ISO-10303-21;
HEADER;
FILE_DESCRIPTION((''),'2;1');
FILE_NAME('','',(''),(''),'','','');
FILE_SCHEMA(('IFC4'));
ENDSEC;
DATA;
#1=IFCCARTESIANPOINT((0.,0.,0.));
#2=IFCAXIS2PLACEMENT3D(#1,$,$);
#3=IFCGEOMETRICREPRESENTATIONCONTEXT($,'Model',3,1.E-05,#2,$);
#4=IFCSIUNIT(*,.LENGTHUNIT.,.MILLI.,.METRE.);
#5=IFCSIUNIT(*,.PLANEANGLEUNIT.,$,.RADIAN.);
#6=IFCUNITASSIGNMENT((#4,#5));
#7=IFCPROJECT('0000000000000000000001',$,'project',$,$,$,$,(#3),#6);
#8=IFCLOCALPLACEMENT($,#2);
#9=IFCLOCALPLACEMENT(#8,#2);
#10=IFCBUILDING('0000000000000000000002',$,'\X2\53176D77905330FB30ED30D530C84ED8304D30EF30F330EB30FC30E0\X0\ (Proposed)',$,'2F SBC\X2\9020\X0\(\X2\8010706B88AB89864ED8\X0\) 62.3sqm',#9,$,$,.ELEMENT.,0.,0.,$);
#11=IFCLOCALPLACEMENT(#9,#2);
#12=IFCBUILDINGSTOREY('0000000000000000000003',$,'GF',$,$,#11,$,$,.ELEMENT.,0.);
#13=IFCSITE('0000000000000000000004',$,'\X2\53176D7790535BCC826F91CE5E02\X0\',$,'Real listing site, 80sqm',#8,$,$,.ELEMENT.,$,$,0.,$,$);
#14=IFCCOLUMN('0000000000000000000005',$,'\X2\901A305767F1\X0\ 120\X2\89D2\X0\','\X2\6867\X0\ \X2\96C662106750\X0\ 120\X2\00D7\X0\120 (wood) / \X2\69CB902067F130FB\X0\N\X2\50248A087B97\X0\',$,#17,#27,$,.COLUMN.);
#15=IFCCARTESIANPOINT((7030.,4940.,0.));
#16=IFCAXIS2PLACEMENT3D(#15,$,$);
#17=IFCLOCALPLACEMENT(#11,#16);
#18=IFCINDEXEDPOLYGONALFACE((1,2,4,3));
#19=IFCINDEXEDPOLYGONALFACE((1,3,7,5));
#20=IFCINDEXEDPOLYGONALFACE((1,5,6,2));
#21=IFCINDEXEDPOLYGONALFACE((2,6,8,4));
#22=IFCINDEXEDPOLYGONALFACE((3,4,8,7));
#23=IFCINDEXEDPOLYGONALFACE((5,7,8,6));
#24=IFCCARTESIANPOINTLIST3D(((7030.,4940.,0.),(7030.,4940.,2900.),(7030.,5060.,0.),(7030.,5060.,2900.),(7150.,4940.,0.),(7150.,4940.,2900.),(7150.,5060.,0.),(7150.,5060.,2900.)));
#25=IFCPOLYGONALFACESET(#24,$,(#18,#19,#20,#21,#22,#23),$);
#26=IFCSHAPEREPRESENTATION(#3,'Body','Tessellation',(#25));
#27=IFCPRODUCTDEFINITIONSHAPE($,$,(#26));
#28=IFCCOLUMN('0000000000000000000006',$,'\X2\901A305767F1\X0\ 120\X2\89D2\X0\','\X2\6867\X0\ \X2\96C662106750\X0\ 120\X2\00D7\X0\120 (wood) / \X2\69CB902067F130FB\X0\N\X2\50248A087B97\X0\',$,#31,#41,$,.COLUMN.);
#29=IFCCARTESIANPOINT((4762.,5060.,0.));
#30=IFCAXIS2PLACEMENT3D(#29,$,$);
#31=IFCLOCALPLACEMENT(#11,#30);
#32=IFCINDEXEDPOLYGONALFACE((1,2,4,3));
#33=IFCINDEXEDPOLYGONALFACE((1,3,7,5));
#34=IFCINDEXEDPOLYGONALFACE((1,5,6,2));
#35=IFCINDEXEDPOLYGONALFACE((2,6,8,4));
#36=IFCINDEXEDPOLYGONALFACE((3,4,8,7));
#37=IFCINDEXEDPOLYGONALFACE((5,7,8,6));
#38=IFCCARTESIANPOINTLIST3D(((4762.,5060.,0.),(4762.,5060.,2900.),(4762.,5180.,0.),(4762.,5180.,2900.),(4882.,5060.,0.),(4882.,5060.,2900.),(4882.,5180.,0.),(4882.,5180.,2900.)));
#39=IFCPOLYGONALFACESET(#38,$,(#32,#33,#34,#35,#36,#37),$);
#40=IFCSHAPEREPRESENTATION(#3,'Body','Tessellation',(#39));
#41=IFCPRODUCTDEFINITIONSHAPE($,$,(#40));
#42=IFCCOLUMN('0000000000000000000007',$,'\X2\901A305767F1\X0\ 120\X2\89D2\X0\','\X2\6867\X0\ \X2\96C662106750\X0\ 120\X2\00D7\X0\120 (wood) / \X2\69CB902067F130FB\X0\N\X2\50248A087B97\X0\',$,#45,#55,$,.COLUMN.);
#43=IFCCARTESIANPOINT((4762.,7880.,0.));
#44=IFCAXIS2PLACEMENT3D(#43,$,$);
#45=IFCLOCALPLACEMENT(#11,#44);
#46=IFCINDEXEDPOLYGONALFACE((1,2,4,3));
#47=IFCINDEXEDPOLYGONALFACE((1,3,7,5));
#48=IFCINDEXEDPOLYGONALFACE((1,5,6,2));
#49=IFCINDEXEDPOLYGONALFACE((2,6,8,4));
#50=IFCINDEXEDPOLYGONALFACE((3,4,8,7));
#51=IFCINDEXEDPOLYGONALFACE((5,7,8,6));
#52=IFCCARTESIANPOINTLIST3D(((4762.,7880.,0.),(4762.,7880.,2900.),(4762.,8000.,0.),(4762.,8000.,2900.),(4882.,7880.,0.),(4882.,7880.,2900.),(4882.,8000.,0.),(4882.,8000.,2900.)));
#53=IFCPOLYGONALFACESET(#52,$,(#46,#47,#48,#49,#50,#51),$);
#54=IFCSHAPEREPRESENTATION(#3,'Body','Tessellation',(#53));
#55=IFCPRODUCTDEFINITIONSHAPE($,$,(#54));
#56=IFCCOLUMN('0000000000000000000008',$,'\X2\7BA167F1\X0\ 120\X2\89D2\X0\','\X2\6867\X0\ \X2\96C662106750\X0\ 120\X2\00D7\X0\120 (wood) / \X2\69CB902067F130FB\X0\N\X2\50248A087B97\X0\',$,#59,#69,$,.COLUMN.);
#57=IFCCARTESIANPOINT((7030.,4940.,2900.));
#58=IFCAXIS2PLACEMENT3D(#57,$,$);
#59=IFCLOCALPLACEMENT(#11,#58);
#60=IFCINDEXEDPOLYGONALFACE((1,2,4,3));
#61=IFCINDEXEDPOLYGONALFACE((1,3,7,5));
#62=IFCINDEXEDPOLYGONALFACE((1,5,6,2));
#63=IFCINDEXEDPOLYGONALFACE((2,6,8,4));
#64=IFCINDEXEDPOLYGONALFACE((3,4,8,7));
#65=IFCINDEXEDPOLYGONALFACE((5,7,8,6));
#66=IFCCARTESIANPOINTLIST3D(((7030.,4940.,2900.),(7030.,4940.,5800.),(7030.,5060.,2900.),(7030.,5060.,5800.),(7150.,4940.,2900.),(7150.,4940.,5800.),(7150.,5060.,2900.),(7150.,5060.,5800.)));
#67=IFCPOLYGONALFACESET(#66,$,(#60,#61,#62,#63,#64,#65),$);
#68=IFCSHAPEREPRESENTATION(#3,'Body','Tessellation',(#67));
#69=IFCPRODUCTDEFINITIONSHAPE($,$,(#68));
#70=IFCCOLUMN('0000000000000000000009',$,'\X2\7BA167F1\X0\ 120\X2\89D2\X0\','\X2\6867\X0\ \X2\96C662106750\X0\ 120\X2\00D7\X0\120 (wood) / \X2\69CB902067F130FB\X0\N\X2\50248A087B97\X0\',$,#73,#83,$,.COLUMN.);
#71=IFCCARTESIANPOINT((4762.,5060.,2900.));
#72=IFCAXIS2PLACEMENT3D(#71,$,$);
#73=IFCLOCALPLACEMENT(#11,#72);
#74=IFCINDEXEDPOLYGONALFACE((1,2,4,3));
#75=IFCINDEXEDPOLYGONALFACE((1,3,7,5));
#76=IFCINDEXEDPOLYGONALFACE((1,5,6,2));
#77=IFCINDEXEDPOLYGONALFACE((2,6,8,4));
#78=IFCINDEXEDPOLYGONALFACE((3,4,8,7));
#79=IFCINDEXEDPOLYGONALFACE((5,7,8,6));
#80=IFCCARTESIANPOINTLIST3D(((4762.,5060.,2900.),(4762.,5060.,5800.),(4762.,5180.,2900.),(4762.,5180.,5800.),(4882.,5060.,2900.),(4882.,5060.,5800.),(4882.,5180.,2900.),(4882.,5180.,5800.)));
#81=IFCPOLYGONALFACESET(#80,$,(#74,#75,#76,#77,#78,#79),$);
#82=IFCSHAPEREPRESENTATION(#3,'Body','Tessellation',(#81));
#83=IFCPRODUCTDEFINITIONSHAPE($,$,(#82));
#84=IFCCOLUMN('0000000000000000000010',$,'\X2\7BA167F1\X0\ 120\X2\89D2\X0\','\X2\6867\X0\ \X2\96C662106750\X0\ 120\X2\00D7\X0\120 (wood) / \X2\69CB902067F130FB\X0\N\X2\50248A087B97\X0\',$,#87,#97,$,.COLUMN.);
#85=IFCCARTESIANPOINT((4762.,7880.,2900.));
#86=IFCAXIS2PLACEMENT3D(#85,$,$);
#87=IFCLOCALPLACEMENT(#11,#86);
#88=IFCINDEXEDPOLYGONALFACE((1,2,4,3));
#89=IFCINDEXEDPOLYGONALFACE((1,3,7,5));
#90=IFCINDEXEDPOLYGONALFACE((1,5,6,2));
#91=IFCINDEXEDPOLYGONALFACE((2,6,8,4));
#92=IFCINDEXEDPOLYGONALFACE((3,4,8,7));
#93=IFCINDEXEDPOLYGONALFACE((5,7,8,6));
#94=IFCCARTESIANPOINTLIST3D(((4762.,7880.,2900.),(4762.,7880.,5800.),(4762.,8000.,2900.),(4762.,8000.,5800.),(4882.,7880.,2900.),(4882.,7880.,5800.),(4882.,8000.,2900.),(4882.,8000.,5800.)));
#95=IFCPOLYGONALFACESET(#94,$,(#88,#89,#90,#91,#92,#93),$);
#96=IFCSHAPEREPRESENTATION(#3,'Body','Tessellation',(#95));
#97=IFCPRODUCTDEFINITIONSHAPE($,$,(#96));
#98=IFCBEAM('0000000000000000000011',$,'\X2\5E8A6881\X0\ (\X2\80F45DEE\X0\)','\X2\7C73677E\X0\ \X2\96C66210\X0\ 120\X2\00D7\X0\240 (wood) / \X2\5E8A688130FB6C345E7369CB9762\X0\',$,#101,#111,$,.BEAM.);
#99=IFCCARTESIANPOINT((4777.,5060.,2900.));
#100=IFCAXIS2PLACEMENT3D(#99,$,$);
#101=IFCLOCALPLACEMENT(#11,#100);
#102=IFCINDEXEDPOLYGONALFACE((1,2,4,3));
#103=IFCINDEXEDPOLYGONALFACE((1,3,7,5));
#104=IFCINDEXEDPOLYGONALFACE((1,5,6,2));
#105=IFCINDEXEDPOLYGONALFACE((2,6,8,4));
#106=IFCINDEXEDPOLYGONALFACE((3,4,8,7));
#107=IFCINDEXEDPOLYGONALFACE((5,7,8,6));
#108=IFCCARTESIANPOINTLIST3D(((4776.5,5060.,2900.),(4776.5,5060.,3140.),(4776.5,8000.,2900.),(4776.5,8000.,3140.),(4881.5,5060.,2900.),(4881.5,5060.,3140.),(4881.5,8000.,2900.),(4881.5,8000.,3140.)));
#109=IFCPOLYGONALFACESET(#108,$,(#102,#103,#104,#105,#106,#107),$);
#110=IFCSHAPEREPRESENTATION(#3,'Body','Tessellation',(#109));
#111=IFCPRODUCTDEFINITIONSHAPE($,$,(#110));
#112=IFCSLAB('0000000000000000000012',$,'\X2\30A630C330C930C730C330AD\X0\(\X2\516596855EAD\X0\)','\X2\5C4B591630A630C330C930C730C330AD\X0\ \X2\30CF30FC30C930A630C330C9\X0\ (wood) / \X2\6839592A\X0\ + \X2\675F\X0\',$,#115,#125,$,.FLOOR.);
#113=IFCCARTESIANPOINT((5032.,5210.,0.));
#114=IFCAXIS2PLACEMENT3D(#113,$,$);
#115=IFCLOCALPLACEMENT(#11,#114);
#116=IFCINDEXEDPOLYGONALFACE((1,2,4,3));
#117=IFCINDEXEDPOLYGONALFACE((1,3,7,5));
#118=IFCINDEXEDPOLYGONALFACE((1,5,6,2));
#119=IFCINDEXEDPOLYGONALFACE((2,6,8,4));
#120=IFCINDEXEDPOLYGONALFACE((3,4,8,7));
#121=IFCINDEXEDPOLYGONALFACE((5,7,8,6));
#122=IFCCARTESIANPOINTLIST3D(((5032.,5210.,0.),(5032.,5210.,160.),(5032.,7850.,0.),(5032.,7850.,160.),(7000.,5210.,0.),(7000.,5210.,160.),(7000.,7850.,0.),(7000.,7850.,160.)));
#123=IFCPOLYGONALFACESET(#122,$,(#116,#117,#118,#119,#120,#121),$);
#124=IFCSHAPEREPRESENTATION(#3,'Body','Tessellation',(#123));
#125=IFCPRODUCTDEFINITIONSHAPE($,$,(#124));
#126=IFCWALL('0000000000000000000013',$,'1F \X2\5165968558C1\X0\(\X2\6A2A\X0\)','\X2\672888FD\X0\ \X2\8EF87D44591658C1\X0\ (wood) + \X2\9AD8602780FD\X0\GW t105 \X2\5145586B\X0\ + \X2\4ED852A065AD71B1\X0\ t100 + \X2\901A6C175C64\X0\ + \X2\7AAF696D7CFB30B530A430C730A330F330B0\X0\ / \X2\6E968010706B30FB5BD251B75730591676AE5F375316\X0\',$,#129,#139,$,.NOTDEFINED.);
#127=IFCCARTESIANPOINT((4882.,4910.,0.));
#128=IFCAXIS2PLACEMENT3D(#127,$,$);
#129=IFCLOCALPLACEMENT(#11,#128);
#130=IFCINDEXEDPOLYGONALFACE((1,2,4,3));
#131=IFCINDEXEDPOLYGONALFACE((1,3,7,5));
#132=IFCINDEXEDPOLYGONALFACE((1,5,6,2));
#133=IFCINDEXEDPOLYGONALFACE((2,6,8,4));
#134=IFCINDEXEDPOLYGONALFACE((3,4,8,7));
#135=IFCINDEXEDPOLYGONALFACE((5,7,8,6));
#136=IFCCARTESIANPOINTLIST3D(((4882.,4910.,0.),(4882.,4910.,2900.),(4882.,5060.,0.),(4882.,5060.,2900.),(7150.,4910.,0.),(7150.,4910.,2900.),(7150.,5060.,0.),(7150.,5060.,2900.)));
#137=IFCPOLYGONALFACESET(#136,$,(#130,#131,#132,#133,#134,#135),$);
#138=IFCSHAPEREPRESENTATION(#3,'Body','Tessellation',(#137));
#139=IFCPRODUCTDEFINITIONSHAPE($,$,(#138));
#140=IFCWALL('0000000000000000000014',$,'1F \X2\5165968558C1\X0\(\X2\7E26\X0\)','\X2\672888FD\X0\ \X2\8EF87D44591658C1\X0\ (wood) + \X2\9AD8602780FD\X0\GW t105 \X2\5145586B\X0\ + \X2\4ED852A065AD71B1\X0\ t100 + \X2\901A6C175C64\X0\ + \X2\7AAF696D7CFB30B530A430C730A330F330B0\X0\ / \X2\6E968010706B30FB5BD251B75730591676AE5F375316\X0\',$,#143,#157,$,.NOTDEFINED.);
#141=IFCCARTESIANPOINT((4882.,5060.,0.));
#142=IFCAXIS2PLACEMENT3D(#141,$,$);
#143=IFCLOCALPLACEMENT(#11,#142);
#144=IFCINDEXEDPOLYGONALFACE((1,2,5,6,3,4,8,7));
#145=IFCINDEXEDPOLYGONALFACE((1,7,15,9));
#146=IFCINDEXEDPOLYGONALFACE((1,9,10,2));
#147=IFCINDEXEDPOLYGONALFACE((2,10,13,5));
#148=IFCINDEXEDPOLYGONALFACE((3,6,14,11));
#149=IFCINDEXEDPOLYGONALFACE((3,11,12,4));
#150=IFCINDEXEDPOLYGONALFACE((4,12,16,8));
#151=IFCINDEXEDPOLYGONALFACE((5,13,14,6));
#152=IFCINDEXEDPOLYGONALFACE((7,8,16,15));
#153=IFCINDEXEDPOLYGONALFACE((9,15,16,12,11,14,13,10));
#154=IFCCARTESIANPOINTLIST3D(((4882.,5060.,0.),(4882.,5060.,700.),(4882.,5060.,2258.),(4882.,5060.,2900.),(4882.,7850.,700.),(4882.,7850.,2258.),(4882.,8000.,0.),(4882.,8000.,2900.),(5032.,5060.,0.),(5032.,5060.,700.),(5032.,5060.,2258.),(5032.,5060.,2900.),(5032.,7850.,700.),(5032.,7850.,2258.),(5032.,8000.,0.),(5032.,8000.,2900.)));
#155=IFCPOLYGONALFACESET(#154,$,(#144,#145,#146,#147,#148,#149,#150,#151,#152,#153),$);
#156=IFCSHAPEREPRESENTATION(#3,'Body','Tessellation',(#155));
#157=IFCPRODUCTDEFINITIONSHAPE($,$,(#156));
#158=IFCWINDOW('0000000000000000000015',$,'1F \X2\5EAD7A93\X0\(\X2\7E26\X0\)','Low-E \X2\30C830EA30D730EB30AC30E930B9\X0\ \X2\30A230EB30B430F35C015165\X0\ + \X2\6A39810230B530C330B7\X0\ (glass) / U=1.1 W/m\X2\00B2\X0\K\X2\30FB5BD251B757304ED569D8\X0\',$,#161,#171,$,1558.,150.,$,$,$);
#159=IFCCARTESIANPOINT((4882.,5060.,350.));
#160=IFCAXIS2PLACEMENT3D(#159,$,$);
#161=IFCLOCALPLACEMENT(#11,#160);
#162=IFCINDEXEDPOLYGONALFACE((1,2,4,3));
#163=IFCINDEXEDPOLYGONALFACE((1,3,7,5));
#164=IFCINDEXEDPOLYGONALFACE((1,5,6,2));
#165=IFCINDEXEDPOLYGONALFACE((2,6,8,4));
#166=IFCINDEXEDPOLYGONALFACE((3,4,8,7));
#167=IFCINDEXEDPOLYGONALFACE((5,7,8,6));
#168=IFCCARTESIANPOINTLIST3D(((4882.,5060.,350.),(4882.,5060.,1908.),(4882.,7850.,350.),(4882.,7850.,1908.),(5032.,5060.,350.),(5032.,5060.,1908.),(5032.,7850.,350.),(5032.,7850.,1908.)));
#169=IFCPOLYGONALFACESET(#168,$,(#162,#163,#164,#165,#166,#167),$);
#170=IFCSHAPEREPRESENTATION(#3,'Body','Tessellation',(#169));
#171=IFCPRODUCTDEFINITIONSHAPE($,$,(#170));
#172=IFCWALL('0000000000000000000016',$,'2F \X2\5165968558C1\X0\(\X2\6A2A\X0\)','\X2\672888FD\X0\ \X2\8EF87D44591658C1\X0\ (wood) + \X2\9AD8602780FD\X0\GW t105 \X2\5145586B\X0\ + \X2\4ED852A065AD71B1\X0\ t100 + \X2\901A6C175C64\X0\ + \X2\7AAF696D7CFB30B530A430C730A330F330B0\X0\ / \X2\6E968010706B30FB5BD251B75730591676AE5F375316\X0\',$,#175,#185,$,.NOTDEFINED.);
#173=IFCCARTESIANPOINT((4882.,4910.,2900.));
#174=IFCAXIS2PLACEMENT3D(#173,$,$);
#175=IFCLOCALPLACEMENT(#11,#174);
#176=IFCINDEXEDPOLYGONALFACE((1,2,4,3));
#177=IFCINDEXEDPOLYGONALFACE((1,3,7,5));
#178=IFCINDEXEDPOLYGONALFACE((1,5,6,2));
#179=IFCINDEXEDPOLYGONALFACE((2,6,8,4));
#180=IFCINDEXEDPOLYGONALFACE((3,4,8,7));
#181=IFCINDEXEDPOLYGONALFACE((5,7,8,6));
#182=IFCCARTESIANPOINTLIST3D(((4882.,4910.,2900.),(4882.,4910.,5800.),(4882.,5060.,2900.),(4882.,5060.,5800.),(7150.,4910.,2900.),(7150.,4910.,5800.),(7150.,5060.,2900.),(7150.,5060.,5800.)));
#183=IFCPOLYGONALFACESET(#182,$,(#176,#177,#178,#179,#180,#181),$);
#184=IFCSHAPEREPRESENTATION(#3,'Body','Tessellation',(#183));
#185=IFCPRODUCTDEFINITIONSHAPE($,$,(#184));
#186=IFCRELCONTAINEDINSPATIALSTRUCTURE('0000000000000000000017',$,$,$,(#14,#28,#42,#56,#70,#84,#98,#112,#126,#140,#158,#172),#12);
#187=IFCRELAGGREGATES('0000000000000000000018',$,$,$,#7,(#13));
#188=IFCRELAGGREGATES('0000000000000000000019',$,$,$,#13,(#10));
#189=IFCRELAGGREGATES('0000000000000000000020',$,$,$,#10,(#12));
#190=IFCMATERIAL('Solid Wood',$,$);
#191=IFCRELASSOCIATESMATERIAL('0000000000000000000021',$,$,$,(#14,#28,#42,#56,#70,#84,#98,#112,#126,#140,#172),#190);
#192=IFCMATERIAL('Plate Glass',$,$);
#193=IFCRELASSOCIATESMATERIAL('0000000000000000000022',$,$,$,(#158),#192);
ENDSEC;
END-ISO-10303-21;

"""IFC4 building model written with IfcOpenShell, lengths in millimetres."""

from ifc_helpers import new_model, si_unit, frame, frame_2d, origin, place, context, project, spatial, rectangle, extrude, material, element, fill, save


model = new_model("IFC4")

# Units and contexts
model_context = context("Model", 3, precision=1e-05, world=origin())
ifc_project = project(units=[si_unit("LENGTHUNIT", "METRE", prefix="MILLI"), si_unit("PLANEANGLEUNIT", "RADIAN")], contexts=[model_context])

# Site, building, storey
site_placement = place(None, origin())
site = spatial("IfcSite", under=ifc_project, at=site_placement, Name="北海道富良野市", ObjectType="Real listing site, 80sqm", CompositionType="ELEMENT", RefElevation=0.0)
building_placement = place(site_placement, origin())
building = spatial("IfcBuilding", under=site, at=building_placement, Name="北海道・ロフト付きワンルーム (Proposed)", ObjectType="2F SBC造(耐火被覆付) 62.3sqm", CompositionType="ELEMENT", ElevationOfRefHeight=0.0, ElevationOfTerrain=0.0)
storey_placement = place(building_placement, origin())
storey = spatial("IfcBuildingStorey", under=building, at=storey_placement, Name="GF", CompositionType="ELEMENT", Elevation=0.0)

# Columns
ifc_material_1 = material(Name="Solid Wood")
column_1_placement = place(storey_placement, frame((7030.0, 4940.0, 0.0)))
element("IfcColumn", 1, at=column_1_placement, inside=storey, material=ifc_material_1, Name="通し柱 120角", Description="桧 集成材 120×120 (wood) / 構造柱・N値計算", PredefinedType="COLUMN", context=model_context, shape_type="SweptSolid", body=[
    extrude(rectangle(XDim=120.0, YDim=120.0, at=frame_2d((60.0, 60.0))), frame((7030.0, 4940.0, 0.0)), (0.0, 0.0, 1.0), 2900.0),
])
column_2_placement = place(storey_placement, frame((4762.0, 5060.0, 0.0)))
element("IfcColumn", 2, at=column_2_placement, inside=storey, material=ifc_material_1, Name="通し柱 120角", Description="桧 集成材 120×120 (wood) / 構造柱・N値計算", PredefinedType="COLUMN", context=model_context, shape_type="SweptSolid", body=[
    extrude(rectangle(XDim=120.0, YDim=120.0, at=frame_2d((60.0, 60.0))), frame((4762.0, 5060.0, 0.0)), (0.0, 0.0, 1.0), 2900.0),
])
column_3_placement = place(storey_placement, frame((4762.0, 7880.0, 0.0)))
element("IfcColumn", 3, at=column_3_placement, inside=storey, material=ifc_material_1, Name="通し柱 120角", Description="桧 集成材 120×120 (wood) / 構造柱・N値計算", PredefinedType="COLUMN", context=model_context, shape_type="SweptSolid", body=[
    extrude(rectangle(XDim=120.0, YDim=120.0, at=frame_2d((60.0, 60.0))), frame((4762.0, 7880.0, 0.0)), (0.0, 0.0, 1.0), 2900.0),
])
column_4_placement = place(storey_placement, frame((7030.0, 4940.0, 2900.0)))
element("IfcColumn", 4, at=column_4_placement, inside=storey, material=ifc_material_1, Name="管柱 120角", Description="桧 集成材 120×120 (wood) / 構造柱・N値計算", PredefinedType="COLUMN", context=model_context, shape_type="SweptSolid", body=[
    extrude(rectangle(XDim=120.0, YDim=120.0, at=frame_2d((60.0, 60.0))), frame((7030.0, 4940.0, 2900.0)), (0.0, 0.0, 1.0), 2900.0),
])
column_5_placement = place(storey_placement, frame((4762.0, 5060.0, 2900.0)))
element("IfcColumn", 5, at=column_5_placement, inside=storey, material=ifc_material_1, Name="管柱 120角", Description="桧 集成材 120×120 (wood) / 構造柱・N値計算", PredefinedType="COLUMN", context=model_context, shape_type="SweptSolid", body=[
    extrude(rectangle(XDim=120.0, YDim=120.0, at=frame_2d((60.0, 60.0))), frame((4762.0, 5060.0, 2900.0)), (0.0, 0.0, 1.0), 2900.0),
])
column_6_placement = place(storey_placement, frame((4762.0, 7880.0, 2900.0)))
element("IfcColumn", 6, at=column_6_placement, inside=storey, material=ifc_material_1, Name="管柱 120角", Description="桧 集成材 120×120 (wood) / 構造柱・N値計算", PredefinedType="COLUMN", context=model_context, shape_type="SweptSolid", body=[
    extrude(rectangle(XDim=120.0, YDim=120.0, at=frame_2d((60.0, 60.0))), frame((4762.0, 7880.0, 2900.0)), (0.0, 0.0, 1.0), 2900.0),
])

# Beam
beam_1_placement = place(storey_placement, frame((4777.0, 5060.0, 2900.0)))
element("IfcBeam", 7, at=beam_1_placement, inside=storey, material=ifc_material_1, Name="床梁 (胴差)", Description="米松 集成 120×240 (wood) / 床梁・水平構面", PredefinedType="BEAM", context=model_context, shape_type="SweptSolid", body=[
    extrude(rectangle(XDim=105.0, YDim=2940.0, at=frame_2d((52.0, 1470.0))), frame((4777.0, 5060.0, 2900.0)), (0.0, 0.0, 1.0), 240.0),
])

# Slab
slab_placement = place(storey_placement, frame((5032.0, 5210.0, 0.0)))
element("IfcSlab", 8, at=slab_placement, inside=storey, material=ifc_material_1, Name="ウッドデッキ(入隅庭)", Description="屋外ウッドデッキ ハードウッド (wood) / 根太 + 束", PredefinedType="FLOOR", context=model_context, shape_type="SweptSolid", body=[
    extrude(rectangle(XDim=1968.0, YDim=2640.0, at=frame_2d((984.0, 1320.0))), frame((5032.0, 5210.0, 0.0)), (0.0, 0.0, 1.0), 160.0),
])

# Wall
wall_1_placement = place(storey_placement, frame((4882.0, 4910.0, 0.0)))
element("IfcWall", 9, at=wall_1_placement, inside=storey, material=ifc_material_1, Name="1F 入隅壁(横)", Description="木製 軸組外壁 (wood) + 高性能GW t105 充填 + 付加断熱 t100 + 通気層 + 窯業系サイディング / 準耐火・寒冷地外皮強化", PredefinedType="NOTDEFINED", context=model_context, shape_type="SweptSolid", body=[
    extrude(rectangle(XDim=2268.0, YDim=150.0, at=frame_2d((1134.0, 75.0))), frame((4882.0, 4910.0, 0.0)), (0.0, 0.0, 1.0), 2900.0),
])

# Wall, opening, window
wall_2_placement = place(storey_placement, frame((4882.0, 5060.0, 0.0)))
wall_2 = element("IfcWall", 10, at=wall_2_placement, inside=storey, material=ifc_material_1, Name="1F 入隅壁(縦)", Description="木製 軸組外壁 (wood) + 高性能GW t105 充填 + 付加断熱 t100 + 通気層 + 窯業系サイディング / 準耐火・寒冷地外皮強化", PredefinedType="NOTDEFINED", context=model_context, shape_type="SweptSolid", body=[
    extrude(rectangle(XDim=150.0, YDim=2940.0, at=frame_2d((75.0, 1470.0))), frame((4882.0, 5060.0, 0.0)), (0.0, 0.0, 1.0), 2900.0),
])
opening_1_placement = place(storey_placement, frame((4882.0, 5060.0, 350.0)))
opening_1 = element("IfcOpeningElement", 11, at=opening_1_placement, cuts=wall_2, PredefinedType="NOTDEFINED", context=model_context, shape_type="SweptSolid", body=[
    extrude(rectangle(XDim=150.0, YDim=2790.0, at=frame_2d((75.0, 1395.0))), frame((4882.0, 5060.0, 350.0)), (0.0, 0.0, 1.0), 1558.0),
])
ifc_material_2 = material(Name="Plate Glass")
window_1_placement = place(storey_placement, frame((4882.0, 5060.0, 350.0)))
window_1 = element("IfcWindow", 12, at=window_1_placement, inside=storey, material=ifc_material_2, Name="1F 庭窓(縦)", Description="Low-E トリプルガラス アルゴン封入 + 樹脂サッシ (glass) / U=1.1 W/m²K・寒冷地仕様", OverallHeight=1558.0, OverallWidth=150.0, context=model_context, shape_type="SweptSolid", body=[
    extrude(rectangle(XDim=150.0, YDim=2790.0, at=frame_2d((75.0, 1395.0))), frame((4882.0, 5060.0, 350.0)), (0.0, 0.0, 1.0), 1558.0),
])
fill(opening_1, window_1)

# Wall
wall_3_placement = place(storey_placement, frame((4882.0, 4910.0, 2900.0)))
element("IfcWall", 13, at=wall_3_placement, inside=storey, material=ifc_material_1, Name="2F 入隅壁(横)", Description="木製 軸組外壁 (wood) + 高性能GW t105 充填 + 付加断熱 t100 + 通気層 + 窯業系サイディング / 準耐火・寒冷地外皮強化", PredefinedType="NOTDEFINED", context=model_context, shape_type="SweptSolid", body=[
    extrude(rectangle(XDim=2268.0, YDim=150.0, at=frame_2d((1134.0, 75.0))), frame((4882.0, 4910.0, 2900.0)), (0.0, 0.0, 1.0), 2900.0),
])

save(model, "model.ifc")
